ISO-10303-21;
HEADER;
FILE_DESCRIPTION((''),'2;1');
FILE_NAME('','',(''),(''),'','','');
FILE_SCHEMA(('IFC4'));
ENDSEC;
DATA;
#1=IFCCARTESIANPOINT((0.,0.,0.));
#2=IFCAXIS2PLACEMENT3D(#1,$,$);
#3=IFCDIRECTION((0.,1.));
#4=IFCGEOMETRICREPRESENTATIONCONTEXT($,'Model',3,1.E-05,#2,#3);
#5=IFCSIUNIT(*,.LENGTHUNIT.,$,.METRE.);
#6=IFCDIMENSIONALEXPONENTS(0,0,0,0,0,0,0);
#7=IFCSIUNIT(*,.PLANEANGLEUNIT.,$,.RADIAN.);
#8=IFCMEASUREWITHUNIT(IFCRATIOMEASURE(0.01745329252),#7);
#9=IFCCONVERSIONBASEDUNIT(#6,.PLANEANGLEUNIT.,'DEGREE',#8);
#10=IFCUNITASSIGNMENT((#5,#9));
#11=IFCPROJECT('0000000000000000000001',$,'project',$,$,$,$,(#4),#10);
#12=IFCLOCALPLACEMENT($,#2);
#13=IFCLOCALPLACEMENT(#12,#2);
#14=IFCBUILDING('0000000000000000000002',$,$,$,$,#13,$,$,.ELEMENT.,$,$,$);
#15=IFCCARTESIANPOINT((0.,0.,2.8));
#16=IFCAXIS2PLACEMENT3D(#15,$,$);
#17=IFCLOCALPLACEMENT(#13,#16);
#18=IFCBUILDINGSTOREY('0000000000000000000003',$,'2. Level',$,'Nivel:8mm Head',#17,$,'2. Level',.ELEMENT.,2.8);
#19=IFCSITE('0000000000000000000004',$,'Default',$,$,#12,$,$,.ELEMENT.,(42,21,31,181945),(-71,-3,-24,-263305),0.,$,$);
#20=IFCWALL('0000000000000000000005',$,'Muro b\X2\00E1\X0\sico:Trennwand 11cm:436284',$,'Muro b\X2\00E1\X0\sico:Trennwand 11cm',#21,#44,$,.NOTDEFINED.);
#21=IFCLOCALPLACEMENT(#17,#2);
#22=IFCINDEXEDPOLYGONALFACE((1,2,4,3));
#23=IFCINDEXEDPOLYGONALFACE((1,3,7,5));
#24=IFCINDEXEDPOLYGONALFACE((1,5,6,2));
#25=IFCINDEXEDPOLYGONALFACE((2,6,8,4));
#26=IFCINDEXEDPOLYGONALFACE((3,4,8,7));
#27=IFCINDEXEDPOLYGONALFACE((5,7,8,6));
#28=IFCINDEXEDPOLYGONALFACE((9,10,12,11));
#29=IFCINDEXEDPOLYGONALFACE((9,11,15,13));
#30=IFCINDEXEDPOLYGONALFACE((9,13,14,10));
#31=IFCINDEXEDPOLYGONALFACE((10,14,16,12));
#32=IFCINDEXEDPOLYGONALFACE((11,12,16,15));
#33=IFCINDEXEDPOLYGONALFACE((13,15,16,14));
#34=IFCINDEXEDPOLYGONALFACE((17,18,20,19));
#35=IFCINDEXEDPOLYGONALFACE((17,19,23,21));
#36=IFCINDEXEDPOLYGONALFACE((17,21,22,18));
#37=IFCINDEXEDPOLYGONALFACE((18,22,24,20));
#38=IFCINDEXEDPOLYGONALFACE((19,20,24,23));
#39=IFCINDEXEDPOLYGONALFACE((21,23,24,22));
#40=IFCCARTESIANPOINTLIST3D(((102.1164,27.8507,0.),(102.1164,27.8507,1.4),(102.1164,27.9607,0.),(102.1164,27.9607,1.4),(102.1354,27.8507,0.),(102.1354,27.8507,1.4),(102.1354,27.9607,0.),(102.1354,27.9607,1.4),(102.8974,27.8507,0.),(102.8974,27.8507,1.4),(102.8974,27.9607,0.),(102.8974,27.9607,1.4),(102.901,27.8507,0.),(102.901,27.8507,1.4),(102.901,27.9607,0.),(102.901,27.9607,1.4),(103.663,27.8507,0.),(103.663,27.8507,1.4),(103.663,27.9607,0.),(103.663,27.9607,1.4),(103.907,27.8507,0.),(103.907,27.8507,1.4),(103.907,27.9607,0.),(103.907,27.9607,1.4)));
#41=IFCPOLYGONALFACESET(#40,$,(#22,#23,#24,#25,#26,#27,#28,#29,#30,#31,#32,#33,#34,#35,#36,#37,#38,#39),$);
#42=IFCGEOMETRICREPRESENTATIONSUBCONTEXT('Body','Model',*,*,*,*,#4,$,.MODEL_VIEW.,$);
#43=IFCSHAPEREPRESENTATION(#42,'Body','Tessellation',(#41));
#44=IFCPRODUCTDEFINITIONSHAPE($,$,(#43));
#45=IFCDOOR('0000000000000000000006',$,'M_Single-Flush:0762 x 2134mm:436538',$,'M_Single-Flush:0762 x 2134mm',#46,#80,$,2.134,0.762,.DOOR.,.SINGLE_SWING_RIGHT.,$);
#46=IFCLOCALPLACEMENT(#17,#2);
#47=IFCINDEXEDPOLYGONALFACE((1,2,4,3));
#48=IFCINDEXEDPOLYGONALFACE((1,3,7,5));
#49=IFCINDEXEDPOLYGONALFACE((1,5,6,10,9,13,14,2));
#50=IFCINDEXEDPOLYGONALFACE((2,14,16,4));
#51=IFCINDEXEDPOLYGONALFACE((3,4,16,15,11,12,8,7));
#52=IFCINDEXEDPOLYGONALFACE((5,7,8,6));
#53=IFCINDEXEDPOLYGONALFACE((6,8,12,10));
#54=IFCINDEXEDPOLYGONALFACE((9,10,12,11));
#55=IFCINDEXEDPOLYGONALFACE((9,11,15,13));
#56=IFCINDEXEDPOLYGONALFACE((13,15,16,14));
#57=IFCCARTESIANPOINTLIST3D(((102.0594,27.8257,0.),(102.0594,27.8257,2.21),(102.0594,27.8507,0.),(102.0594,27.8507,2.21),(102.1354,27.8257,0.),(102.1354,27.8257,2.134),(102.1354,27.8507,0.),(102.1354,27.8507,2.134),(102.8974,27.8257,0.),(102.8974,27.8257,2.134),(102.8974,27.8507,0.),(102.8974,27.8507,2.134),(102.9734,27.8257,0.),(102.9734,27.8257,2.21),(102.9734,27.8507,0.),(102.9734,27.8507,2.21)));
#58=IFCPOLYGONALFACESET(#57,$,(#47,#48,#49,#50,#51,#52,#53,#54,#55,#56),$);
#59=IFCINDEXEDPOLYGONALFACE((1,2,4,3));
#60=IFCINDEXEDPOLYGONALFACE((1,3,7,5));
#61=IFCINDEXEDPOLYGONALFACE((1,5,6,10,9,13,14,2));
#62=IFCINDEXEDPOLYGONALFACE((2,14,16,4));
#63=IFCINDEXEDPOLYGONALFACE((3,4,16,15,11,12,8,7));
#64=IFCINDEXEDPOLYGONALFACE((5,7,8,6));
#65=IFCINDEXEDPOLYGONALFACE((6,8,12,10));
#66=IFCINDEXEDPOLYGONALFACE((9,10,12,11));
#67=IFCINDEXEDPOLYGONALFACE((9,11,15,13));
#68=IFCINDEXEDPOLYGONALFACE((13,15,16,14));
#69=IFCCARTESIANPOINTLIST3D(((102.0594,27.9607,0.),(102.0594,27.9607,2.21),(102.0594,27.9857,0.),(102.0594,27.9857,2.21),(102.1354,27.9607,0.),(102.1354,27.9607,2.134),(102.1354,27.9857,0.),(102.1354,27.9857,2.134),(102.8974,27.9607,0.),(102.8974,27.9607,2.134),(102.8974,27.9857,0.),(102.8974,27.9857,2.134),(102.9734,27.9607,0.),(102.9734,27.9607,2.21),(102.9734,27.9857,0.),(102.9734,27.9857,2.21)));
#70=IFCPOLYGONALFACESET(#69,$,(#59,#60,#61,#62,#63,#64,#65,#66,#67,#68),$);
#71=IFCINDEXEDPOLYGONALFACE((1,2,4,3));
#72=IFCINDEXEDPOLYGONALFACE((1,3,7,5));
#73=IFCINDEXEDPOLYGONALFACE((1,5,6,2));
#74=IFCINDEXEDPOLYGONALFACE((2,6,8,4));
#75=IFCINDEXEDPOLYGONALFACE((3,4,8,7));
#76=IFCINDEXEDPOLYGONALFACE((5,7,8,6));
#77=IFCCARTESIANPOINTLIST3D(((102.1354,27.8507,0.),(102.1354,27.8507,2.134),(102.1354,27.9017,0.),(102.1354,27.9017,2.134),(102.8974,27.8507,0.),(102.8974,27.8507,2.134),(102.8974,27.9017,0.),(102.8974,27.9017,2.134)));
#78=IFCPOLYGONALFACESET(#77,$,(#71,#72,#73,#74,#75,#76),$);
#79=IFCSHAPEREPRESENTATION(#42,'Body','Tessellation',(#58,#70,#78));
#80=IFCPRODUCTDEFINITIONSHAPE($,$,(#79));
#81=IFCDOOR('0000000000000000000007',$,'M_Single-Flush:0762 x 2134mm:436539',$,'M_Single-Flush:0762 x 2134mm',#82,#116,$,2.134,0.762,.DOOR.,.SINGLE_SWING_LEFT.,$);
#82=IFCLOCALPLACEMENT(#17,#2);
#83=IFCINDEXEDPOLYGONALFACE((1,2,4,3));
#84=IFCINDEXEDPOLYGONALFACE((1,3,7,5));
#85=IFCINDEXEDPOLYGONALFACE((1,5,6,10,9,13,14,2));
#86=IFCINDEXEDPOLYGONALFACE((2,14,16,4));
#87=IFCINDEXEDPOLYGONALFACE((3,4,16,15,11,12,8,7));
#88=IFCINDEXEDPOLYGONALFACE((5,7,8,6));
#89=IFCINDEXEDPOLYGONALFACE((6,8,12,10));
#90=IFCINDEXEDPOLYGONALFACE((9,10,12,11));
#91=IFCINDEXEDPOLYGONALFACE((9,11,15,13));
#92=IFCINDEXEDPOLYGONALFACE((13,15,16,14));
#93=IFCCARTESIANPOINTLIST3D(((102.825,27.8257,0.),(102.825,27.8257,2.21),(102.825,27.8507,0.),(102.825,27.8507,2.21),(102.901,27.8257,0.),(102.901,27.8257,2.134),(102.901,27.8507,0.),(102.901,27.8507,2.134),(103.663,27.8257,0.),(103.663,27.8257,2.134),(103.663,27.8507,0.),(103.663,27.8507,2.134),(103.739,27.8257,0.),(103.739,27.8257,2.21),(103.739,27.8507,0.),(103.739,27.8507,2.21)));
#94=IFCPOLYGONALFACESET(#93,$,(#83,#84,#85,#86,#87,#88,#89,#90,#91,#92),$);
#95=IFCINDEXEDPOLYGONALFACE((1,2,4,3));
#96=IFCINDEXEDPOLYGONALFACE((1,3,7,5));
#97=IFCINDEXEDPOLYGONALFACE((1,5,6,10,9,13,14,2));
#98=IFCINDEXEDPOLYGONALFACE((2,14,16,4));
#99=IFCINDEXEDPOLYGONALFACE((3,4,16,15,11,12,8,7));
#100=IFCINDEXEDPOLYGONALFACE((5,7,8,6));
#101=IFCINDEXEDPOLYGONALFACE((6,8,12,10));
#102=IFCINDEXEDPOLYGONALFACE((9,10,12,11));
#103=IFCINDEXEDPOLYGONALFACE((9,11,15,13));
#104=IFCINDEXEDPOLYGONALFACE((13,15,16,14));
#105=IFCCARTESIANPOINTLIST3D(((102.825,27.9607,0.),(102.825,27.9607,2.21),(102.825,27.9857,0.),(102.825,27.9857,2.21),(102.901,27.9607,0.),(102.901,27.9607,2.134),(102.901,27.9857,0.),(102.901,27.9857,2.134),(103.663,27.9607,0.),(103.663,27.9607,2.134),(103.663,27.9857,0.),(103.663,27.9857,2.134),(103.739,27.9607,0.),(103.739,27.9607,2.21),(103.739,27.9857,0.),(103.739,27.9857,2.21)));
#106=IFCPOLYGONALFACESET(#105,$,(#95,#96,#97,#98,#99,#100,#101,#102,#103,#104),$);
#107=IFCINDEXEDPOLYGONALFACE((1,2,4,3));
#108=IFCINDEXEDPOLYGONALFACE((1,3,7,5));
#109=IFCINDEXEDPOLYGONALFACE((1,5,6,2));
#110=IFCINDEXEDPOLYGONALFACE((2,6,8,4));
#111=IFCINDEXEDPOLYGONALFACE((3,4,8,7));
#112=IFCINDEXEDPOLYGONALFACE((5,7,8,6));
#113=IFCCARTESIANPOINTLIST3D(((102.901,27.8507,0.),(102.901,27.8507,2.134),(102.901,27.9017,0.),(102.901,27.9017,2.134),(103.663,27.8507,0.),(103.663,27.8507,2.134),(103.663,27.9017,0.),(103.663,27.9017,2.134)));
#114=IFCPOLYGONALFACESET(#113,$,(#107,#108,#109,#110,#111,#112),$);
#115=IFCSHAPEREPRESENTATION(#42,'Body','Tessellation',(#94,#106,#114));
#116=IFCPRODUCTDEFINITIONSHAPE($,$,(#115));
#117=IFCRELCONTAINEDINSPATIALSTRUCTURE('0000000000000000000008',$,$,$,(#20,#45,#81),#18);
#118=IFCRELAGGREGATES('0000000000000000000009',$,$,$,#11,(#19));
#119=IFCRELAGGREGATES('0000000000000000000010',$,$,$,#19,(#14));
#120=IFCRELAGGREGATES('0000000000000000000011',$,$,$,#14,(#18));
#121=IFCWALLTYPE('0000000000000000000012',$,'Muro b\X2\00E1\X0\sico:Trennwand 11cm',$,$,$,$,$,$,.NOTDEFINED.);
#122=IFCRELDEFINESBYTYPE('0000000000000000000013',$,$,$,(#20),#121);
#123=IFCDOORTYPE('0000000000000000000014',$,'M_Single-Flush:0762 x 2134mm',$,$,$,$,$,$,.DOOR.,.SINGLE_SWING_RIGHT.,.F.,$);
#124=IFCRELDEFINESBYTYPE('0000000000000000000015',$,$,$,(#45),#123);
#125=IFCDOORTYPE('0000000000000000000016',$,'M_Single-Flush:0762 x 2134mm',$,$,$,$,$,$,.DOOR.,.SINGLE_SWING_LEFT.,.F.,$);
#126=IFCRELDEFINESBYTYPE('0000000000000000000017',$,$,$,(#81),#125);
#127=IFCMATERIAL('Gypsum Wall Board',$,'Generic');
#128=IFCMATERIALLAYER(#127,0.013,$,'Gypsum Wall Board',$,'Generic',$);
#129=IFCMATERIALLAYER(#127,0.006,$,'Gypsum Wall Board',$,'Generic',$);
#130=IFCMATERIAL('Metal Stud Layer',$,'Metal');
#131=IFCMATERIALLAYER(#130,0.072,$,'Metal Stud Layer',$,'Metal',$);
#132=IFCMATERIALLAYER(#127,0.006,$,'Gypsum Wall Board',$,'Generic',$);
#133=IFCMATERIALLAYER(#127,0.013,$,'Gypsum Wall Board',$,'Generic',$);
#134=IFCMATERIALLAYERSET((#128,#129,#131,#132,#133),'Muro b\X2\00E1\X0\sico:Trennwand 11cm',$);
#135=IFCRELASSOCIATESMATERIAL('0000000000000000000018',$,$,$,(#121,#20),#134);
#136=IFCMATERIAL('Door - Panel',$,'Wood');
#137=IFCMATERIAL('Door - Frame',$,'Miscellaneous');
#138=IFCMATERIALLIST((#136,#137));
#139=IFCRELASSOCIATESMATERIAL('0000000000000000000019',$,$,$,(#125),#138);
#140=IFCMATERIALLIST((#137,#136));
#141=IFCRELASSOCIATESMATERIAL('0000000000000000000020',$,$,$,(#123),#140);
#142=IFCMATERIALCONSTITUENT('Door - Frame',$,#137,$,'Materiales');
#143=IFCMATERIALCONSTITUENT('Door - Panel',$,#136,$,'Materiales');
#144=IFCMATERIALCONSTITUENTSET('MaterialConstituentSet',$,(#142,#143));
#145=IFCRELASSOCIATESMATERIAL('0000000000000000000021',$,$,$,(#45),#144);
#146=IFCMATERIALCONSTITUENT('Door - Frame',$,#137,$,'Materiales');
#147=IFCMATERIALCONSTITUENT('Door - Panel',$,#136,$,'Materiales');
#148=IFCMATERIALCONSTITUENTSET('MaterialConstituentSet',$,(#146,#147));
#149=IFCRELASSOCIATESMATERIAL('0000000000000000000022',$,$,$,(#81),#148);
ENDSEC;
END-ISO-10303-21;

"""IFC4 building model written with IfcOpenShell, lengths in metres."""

from ifc_helpers import new_model, entity, si_unit, converted_unit, direction, frame, frame_2d, origin, origin_2d_with_axis, place, context, subcontext, project, spatial, polyline, rectangle, outline, extrude, clip, halfspace, source, transform, mapped, material, material_list, layer, layer_set, layer_usage, constituent, constituent_set, type_object, type_shapes, element, fill, save


model = new_model("IFC4")

# Units and contexts
model_context = context("Model", 3, precision=1e-05, world=origin(), true_north=direction((0.0, 1.0)))
body_context = subcontext(model_context, "Body", "Model", "MODEL_VIEW")
ifc_project = project(units=[si_unit("LENGTHUNIT", "METRE"), converted_unit("PLANEANGLEUNIT", "DEGREE", entity("IfcRatioMeasure", 0.01745329252), si_unit("PLANEANGLEUNIT", "RADIAN"), dimensions=[0, 0, 0, 0, 0, 0, 0])], contexts=[model_context])

# Site, building, storey
site_placement = place(None, origin())
site = spatial("IfcSite", under=ifc_project, at=site_placement, Name="Default", CompositionType="ELEMENT", RefLatitude=(42, 21, 31, 181945), RefLongitude=(-71, -3, -24, -263305), RefElevation=0.0)
building_placement = place(site_placement, origin())
building = spatial("IfcBuilding", under=site, at=building_placement, CompositionType="ELEMENT")
storey_placement = place(building_placement, frame((0.0, 0.0, 2.8)))
storey = spatial("IfcBuildingStorey", under=building, at=storey_placement, Name="2. Level", ObjectType="Nivel:8mm Head", LongName="2. Level", CompositionType="ELEMENT", Elevation=2.8)

# Shared definitions
ifc_material_1 = material(Name="Gypsum Wall Board", Category="Generic")
ifc_layer_1 = layer(ifc_material_1, 0.013, Name="Gypsum Wall Board", Category="Generic")
ifc_layer_2 = layer(ifc_material_1, 0.006, Name="Gypsum Wall Board", Category="Generic")
ifc_material_2 = material(Name="Metal Stud Layer", Category="Metal")
ifc_layer_3 = layer(ifc_material_2, 0.072, Name="Metal Stud Layer", Category="Metal")
ifc_layer_4 = layer(ifc_material_1, 0.006, Name="Gypsum Wall Board", Category="Generic")
ifc_layer_5 = layer(ifc_material_1, 0.013, Name="Gypsum Wall Board", Category="Generic")
ifc_layer_set_1 = layer_set([ifc_layer_1, ifc_layer_2, ifc_layer_3, ifc_layer_4, ifc_layer_5], Name="Muro básico:Trennwand 11cm")
wall_type_1 = type_object("IfcWallType", Name="Muro básico:Trennwand 11cm", PredefinedType="NOTDEFINED", material=ifc_layer_set_1)

# Shared definitions
ifc_material_3 = material(Name="Door - Frame", Category="Miscellaneous")
ifc_material_4 = material(Name="Door - Panel", Category="Wood")
ifc_material_list_1 = material_list([ifc_material_4, ifc_material_3])
door_type_1 = type_object("IfcDoorType", Name="M_Single-Flush:0762 x 2134mm", OperationType="SINGLE_SWING_LEFT", ParameterTakesPrecedence=False, PredefinedType="DOOR", material=ifc_material_list_1)
shared_shape_1 = source(origin(), body_context, "Body", "SweptSolid", [
    extrude(outline(polyline([(-0.457, -1.124), (0.457, -1.124), (0.457, 1.086), (0.381, 1.086), (0.381, -1.048), (-0.381, -1.048), (-0.381, 1.086), (-0.457, 1.086), (-0.457, -1.124)])), frame((0.381, 0.135, 1.086), z_axis=(0.0, -1.0, 0.0), x_axis=(-1.0, 0.0, 0.0)), (0.0, 0.0, 1.0), 0.025),
    extrude(outline(polyline([(-1.124, -0.457), (1.086, -0.457), (1.086, -0.381), (-1.048, -0.381), (-1.048, 0.381), (1.086, 0.381), (1.086, 0.457), (-1.124, 0.457), (-1.124, -0.457)])), frame((0.381, 0.0, 1.086), z_axis=(0.0, -1.0, 0.0), x_axis=(0.0, 0.0, -1.0)), (0.0, 0.0, 1.0), 0.025),
    extrude(rectangle(XDim=0.762, YDim=0.051, at=origin_2d_with_axis()), frame((0.381, 0.0845, 0.0)), (0.0, 0.0, 1.0), 2.134),
])
type_shapes(door_type_1, [shared_shape_1])

# Wall, openings, doors
ifc_layer_usage_1 = layer_usage(ifc_layer_set_1, "AXIS2", "NEGATIVE", 0.055)
wall_1_placement = place(storey_placement, frame((103.907, 27.9057, 0.0), z_axis=(0.0, 0.0, 1.0), x_axis=(-1.0, 0.0, 0.0)))
wall_1 = element("IfcWall", 1, at=wall_1_placement, inside=storey, type_object=wall_type_1, material=ifc_layer_usage_1, Name="Muro básico:Trennwand 11cm:436284", ObjectType="Muro básico:Trennwand 11cm", PredefinedType="NOTDEFINED", context=body_context, shape_type="Clipping", body=[
    clip(extrude(rectangle(XDim=1.7906, YDim=0.11, at=frame_2d((0.8953, 0.0), x_axis=(-1.0, 0.0))), origin(), (0.0, 0.0, 1.0), 1.4), halfspace(origin(), True)),
])
opening_1_placement = place(wall_1_placement, frame((1.0096, -0.055, 0.0)))
opening_1 = element("IfcOpeningElement", 2, at=opening_1_placement, cuts=wall_1, ObjectType="Opening", PredefinedType="OPENING", context=body_context, shape_type="SweptSolid", body=[
    extrude(rectangle(XDim=0.762, YDim=2.134, at=frame_2d((1.067, 0.381), x_axis=(0.0, 1.0))), frame((0.0, 0.0, 0.0), z_axis=(0.0, 1.0, 0.0), x_axis=(0.0, 0.0, 1.0)), (0.0, 0.0, 1.0), 0.11),
])
opening_2_placement = place(wall_1_placement, frame((0.244, -0.055, 0.0)))
opening_2 = element("IfcOpeningElement", 3, at=opening_2_placement, cuts=wall_1, ObjectType="Opening", PredefinedType="OPENING", context=body_context, shape_type="SweptSolid", body=[
    extrude(rectangle(XDim=0.762, YDim=2.134, at=frame_2d((1.067, 0.381), x_axis=(0.0, -1.0))), frame((0.0, 0.0, 0.0), z_axis=(0.0, 1.0, 0.0), x_axis=(0.0, 0.0, 1.0)), (0.0, 0.0, 1.0), 0.11),
])
ifc_constituent_1 = constituent(ifc_material_3, Name="Door - Frame", Category="Materiales")
ifc_constituent_2 = constituent(ifc_material_4, Name="Door - Panel", Category="Materiales")
ifc_constituent_set_1 = constituent_set(constituents=[ifc_constituent_1, ifc_constituent_2], Name="MaterialConstituentSet")
ifc_material_list_2 = material_list([ifc_material_3, ifc_material_4])
door_type_2 = type_object("IfcDoorType", Name="M_Single-Flush:0762 x 2134mm", OperationType="SINGLE_SWING_RIGHT", ParameterTakesPrecedence=False, PredefinedType="DOOR", material=ifc_material_list_2)
shared_shape_2 = source(origin(), body_context, "Body", "SweptSolid", [
    extrude(outline(polyline([(-0.457, -1.124), (0.457, -1.124), (0.457, 1.086), (0.381, 1.086), (0.381, -1.048), (-0.381, -1.048), (-0.381, 1.086), (-0.457, 1.086), (-0.457, -1.124)])), frame((0.381, 0.11, 1.086), z_axis=(0.0, 1.0, 0.0), x_axis=(1.0, 0.0, 0.0)), (0.0, 0.0, 1.0), 0.025),
    extrude(outline(polyline([(-1.124, -0.457), (1.086, -0.457), (1.086, -0.381), (-1.048, -0.381), (-1.048, 0.381), (1.086, 0.381), (1.086, 0.457), (-1.124, 0.457), (-1.124, -0.457)])), frame((0.381, -0.025, 1.086), z_axis=(0.0, 1.0, 0.0), x_axis=(0.0, 0.0, -1.0)), (0.0, 0.0, 1.0), 0.025),
    extrude(rectangle(XDim=0.051, YDim=0.762, at=origin_2d_with_axis()), frame((0.381, 0.0845, 0.0), z_axis=(0.0, 0.0, 1.0), x_axis=(0.0, 1.0, 0.0)), (0.0, 0.0, 1.0), 2.134),
])
type_shapes(door_type_2, [shared_shape_2])
door_1_placement = place(opening_1_placement, origin())
door_1 = element("IfcDoor", 4, at=door_1_placement, inside=storey, type_object=door_type_2, material=ifc_constituent_set_1, Name="M_Single-Flush:0762 x 2134mm:436538", ObjectType="M_Single-Flush:0762 x 2134mm", OperationType="SINGLE_SWING_RIGHT", OverallHeight=2.134, OverallWidth=0.762, PredefinedType="DOOR", context=body_context, shape_type="MappedRepresentation", body=[
    mapped(shared_shape_2, transform((0.0, 0.0, 0.0), scale=1.0)),
])
fill(opening_1, door_1)
ifc_constituent_3 = constituent(ifc_material_3, Name="Door - Frame", Category="Materiales")
ifc_constituent_4 = constituent(ifc_material_4, Name="Door - Panel", Category="Materiales")
ifc_constituent_set_2 = constituent_set(constituents=[ifc_constituent_3, ifc_constituent_4], Name="MaterialConstituentSet")
door_2_placement = place(opening_2_placement, origin())
door_2 = element("IfcDoor", 5, at=door_2_placement, inside=storey, type_object=door_type_1, material=ifc_constituent_set_2, Name="M_Single-Flush:0762 x 2134mm:436539", ObjectType="M_Single-Flush:0762 x 2134mm", OperationType="SINGLE_SWING_LEFT", OverallHeight=2.134, OverallWidth=0.762, PredefinedType="DOOR", context=body_context, shape_type="MappedRepresentation", body=[
    mapped(shared_shape_1, transform((0.0, 0.0, 0.0), scale=1.0)),
])
fill(opening_2, door_2)

save(model, "model.ifc")
